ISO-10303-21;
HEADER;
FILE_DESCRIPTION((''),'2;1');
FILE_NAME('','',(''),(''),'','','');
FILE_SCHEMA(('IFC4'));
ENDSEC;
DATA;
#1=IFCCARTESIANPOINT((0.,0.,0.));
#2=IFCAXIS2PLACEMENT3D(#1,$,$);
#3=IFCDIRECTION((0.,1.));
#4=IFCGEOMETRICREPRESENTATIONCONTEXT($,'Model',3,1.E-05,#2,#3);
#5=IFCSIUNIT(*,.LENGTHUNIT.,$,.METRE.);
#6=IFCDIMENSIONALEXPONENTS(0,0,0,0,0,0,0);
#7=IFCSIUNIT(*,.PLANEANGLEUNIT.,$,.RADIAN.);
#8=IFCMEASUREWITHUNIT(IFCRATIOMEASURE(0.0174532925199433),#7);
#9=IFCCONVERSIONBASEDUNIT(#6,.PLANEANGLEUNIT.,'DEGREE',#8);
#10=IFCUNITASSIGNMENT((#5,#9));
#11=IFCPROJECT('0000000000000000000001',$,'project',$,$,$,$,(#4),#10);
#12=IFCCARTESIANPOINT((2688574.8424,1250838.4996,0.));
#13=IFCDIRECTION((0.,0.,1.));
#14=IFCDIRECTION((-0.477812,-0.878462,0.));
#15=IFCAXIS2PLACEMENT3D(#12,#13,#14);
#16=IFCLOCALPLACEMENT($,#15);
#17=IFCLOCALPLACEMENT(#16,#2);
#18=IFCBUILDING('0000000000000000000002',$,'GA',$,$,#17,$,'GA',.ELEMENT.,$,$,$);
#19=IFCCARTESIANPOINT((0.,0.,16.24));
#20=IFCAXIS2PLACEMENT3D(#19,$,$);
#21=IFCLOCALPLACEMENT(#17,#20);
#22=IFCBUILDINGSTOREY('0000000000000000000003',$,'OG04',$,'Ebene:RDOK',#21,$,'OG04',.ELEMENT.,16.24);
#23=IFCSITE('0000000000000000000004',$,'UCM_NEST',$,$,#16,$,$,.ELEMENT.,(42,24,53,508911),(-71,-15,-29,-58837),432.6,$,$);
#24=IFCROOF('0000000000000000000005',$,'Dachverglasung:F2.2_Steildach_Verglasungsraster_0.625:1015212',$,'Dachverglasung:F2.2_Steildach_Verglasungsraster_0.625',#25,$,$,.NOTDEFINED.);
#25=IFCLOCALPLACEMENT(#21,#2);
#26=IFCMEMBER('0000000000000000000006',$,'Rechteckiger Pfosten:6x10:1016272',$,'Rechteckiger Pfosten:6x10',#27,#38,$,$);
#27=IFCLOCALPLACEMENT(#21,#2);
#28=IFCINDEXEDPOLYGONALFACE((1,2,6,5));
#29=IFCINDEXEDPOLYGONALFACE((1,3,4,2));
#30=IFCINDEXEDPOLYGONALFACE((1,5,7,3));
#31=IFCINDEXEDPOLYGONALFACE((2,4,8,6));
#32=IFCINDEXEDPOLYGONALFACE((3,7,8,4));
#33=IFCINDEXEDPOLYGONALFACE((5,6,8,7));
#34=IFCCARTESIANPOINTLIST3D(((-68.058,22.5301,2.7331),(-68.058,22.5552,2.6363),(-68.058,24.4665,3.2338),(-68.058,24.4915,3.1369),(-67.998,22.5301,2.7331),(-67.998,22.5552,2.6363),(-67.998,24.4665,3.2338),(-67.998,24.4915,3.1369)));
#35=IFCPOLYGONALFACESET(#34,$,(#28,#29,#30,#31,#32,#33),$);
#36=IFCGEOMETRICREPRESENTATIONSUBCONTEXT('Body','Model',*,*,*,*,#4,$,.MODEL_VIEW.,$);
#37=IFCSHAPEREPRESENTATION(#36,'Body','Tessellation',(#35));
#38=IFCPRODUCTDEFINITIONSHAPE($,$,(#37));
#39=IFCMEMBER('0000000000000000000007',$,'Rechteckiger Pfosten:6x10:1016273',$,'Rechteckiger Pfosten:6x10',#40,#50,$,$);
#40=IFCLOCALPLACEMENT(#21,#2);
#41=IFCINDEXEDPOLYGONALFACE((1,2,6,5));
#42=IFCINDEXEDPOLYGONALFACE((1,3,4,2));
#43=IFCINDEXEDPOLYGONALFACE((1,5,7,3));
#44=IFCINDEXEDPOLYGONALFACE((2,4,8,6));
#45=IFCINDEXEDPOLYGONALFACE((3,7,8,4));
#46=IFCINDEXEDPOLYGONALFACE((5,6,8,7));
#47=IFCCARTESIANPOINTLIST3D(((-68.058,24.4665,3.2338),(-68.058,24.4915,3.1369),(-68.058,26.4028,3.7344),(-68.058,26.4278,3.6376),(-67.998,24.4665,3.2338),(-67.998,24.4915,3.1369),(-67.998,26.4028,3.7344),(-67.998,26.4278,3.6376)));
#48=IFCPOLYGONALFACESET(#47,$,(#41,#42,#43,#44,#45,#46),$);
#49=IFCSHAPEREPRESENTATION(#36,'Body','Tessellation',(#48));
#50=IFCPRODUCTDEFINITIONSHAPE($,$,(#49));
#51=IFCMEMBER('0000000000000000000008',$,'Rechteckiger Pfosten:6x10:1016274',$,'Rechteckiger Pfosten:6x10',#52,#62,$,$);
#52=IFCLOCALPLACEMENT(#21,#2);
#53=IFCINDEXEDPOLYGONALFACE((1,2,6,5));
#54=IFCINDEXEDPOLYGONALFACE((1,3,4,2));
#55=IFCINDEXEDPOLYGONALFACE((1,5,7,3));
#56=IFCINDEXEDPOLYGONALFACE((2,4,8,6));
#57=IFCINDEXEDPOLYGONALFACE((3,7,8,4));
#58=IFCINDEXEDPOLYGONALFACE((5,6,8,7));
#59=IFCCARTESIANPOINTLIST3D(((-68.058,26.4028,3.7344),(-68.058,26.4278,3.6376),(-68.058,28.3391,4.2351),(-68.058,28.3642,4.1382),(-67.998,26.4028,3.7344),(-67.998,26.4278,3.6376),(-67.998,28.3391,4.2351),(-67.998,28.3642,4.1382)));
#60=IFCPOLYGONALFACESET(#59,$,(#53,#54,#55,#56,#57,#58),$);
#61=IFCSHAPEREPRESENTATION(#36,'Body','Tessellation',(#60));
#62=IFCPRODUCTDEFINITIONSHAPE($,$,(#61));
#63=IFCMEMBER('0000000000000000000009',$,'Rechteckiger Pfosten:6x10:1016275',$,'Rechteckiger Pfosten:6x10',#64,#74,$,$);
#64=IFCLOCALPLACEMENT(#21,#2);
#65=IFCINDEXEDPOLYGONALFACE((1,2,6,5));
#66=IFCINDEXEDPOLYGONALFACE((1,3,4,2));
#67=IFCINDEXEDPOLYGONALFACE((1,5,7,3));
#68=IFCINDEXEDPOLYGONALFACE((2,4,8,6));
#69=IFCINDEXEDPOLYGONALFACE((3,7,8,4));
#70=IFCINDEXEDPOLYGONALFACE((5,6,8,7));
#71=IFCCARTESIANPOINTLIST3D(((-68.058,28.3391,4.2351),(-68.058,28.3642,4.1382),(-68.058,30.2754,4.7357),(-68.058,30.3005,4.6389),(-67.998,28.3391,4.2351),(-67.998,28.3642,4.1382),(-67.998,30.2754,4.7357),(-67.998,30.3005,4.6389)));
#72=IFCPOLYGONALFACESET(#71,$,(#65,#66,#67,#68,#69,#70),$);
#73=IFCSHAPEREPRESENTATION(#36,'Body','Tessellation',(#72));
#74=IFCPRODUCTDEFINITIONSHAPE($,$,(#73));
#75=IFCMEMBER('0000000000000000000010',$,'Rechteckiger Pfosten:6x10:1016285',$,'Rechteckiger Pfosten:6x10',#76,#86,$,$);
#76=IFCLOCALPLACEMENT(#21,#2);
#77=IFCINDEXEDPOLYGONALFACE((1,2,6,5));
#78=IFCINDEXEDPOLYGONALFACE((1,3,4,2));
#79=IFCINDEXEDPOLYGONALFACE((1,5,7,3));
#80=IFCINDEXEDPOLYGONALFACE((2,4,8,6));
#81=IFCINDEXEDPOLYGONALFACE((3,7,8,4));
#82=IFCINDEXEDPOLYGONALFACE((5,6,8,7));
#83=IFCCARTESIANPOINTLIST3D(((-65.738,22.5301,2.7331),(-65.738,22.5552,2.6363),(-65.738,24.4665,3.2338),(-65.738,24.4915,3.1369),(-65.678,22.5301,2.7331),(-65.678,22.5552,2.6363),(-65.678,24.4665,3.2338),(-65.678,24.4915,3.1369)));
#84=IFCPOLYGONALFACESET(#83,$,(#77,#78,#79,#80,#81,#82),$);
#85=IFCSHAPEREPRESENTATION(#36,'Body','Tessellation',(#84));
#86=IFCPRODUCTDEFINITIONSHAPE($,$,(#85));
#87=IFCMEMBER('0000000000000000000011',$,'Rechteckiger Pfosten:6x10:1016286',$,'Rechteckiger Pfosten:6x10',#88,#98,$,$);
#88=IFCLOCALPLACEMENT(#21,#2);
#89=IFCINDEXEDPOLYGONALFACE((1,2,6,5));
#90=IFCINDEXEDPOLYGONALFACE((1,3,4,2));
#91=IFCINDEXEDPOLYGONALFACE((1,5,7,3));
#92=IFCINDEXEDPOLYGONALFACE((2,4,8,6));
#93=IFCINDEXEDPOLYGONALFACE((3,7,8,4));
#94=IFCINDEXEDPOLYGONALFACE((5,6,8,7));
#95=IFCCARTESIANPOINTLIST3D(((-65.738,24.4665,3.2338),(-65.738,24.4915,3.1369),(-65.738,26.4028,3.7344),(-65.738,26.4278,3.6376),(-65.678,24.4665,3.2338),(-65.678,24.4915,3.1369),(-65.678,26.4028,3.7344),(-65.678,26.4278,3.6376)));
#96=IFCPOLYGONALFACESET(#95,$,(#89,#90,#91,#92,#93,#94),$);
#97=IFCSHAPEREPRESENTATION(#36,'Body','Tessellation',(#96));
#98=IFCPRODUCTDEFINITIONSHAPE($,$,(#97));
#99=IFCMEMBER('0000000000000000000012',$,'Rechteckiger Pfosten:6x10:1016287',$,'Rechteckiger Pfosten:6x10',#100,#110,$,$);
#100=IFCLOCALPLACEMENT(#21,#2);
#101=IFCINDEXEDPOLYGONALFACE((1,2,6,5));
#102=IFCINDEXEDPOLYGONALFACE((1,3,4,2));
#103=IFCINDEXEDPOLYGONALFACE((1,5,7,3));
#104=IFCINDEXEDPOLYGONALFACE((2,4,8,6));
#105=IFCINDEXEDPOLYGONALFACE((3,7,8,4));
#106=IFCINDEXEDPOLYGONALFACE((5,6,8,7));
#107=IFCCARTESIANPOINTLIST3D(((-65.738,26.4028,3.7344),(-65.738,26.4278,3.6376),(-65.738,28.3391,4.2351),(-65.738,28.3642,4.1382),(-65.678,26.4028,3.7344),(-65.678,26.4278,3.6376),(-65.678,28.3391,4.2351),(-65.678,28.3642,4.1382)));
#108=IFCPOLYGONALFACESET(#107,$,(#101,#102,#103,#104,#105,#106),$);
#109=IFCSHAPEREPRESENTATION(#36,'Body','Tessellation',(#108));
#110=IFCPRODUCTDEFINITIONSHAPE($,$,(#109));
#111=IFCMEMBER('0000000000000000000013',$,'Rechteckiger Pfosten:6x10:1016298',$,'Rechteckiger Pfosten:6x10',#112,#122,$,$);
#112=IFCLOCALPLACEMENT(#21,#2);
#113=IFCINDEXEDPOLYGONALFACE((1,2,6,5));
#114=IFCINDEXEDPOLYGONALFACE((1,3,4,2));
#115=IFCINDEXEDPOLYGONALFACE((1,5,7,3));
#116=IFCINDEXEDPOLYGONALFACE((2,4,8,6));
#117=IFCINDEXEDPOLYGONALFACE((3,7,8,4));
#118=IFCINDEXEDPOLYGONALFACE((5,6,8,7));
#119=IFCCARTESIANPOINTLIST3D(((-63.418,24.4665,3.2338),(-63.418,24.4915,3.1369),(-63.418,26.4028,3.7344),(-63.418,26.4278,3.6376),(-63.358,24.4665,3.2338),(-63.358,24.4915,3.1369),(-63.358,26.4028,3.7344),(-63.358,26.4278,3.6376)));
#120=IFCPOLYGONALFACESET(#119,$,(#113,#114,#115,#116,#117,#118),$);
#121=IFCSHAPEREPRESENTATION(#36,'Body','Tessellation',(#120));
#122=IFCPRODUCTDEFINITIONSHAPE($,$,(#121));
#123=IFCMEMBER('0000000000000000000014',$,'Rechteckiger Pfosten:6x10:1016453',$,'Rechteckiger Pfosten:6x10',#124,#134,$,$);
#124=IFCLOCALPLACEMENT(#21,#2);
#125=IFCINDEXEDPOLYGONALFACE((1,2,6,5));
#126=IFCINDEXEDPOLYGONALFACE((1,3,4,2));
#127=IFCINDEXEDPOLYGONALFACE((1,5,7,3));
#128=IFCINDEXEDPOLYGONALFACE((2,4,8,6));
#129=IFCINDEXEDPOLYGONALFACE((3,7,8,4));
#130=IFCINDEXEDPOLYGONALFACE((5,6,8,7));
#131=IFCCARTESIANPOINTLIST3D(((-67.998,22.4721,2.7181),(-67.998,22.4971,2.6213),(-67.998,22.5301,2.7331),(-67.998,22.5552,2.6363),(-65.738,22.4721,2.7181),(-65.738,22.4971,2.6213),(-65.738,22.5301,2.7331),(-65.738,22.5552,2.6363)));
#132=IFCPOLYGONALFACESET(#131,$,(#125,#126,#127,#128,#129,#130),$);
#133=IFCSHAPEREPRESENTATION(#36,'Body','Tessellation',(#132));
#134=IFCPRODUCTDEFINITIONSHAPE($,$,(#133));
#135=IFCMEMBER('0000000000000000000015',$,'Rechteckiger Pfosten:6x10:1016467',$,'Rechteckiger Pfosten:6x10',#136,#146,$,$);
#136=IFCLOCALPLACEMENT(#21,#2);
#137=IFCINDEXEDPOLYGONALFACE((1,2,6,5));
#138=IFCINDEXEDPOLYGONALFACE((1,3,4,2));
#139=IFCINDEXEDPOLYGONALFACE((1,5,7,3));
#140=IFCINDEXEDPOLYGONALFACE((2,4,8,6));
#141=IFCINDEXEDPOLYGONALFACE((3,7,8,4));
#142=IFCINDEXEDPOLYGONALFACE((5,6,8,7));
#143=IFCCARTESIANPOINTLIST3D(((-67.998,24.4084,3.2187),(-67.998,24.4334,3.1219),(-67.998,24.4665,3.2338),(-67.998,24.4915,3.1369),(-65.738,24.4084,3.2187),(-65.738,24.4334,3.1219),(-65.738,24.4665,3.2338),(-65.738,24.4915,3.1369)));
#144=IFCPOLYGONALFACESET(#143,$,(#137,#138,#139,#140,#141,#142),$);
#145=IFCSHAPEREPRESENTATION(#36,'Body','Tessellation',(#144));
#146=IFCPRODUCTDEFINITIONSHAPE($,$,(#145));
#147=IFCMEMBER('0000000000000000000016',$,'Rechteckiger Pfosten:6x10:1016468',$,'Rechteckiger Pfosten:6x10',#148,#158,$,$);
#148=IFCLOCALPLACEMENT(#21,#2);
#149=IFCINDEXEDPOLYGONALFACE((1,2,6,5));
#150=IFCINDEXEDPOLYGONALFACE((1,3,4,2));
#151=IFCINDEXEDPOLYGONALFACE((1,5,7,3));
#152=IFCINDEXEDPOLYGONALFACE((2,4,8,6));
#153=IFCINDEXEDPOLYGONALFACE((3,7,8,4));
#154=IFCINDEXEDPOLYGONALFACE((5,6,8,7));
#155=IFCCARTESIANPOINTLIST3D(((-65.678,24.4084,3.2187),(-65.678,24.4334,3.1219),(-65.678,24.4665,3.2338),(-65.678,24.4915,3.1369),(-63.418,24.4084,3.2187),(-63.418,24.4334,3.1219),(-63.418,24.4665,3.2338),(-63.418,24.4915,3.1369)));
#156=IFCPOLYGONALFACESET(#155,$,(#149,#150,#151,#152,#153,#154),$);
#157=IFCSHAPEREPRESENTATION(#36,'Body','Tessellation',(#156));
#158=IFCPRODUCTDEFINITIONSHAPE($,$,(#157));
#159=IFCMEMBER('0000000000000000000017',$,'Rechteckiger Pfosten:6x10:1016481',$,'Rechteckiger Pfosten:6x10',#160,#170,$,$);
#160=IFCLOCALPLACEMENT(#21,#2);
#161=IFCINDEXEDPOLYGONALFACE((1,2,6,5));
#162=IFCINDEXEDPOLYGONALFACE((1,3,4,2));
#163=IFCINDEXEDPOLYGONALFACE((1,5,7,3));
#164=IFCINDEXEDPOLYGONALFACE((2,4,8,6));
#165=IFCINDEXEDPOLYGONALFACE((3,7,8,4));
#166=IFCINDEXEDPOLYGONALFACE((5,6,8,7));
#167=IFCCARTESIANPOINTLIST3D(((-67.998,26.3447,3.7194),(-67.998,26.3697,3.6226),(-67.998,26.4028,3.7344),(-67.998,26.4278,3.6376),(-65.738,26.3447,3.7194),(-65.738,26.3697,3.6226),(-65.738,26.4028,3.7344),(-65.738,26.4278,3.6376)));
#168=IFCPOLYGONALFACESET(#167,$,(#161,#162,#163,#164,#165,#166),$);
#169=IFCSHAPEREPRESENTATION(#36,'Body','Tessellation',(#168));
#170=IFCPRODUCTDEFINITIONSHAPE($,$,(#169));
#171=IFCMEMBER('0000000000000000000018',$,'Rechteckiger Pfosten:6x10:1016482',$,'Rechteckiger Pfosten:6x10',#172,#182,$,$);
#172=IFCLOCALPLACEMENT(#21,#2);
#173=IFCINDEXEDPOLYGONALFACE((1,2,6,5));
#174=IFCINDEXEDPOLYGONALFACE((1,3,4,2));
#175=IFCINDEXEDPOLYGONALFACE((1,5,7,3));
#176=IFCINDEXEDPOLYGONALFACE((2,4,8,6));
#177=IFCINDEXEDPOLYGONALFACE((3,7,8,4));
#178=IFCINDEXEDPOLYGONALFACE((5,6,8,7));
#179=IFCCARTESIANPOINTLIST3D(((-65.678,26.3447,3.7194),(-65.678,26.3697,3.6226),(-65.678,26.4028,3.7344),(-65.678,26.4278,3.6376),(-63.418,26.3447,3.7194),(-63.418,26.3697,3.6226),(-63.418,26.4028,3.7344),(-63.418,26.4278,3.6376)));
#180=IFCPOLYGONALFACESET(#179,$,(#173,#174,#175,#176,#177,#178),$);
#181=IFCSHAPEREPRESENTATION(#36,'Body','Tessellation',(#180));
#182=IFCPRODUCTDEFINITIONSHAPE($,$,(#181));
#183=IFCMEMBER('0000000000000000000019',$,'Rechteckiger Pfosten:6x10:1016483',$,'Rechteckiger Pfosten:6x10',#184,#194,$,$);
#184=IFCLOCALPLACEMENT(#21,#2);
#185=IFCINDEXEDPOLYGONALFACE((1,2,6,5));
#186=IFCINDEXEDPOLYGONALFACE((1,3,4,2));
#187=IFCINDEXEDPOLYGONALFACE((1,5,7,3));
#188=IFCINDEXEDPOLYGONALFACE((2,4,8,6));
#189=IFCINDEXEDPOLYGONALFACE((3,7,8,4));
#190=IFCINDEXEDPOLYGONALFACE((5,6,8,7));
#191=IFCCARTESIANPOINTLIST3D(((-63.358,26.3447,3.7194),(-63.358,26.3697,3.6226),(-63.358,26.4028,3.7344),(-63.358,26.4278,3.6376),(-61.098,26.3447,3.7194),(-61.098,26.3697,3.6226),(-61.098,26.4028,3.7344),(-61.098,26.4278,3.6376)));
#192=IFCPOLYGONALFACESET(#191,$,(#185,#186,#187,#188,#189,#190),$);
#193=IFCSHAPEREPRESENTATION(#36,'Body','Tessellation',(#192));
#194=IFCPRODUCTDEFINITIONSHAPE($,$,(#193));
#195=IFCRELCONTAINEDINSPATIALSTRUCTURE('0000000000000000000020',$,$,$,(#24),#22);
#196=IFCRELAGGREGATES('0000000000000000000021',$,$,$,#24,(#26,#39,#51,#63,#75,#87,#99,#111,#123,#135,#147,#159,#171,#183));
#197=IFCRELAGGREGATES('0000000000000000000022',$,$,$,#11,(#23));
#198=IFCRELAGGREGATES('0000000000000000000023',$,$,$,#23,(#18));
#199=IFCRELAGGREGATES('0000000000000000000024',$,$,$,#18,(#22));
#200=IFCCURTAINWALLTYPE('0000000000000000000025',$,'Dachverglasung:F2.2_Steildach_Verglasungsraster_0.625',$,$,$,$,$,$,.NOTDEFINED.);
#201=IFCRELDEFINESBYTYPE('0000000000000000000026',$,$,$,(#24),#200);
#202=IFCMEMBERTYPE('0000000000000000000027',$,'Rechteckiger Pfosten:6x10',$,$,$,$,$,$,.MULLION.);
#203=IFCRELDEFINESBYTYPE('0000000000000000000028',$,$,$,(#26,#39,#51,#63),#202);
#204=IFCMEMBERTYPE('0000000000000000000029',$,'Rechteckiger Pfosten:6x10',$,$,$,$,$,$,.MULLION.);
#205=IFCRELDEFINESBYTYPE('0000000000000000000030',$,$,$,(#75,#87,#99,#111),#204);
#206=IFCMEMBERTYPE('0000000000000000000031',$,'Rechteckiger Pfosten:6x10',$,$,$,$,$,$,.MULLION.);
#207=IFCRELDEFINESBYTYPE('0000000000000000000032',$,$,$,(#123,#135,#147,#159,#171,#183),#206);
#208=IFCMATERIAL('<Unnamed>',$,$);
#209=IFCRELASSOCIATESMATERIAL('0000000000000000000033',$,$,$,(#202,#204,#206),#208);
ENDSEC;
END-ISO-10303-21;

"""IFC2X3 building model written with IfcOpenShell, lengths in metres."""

from ifc_helpers import new_model, entity, si_unit, converted_unit, direction, frame, origin, origin_2d_with_axis, place, context, subcontext, project, spatial, rectangle, extrude, source, transform, mapped, material, type_object, type_shapes, element, aggregate, save


model = new_model("IFC2X3")

# Units and contexts
model_context = context("Model", 3, precision=1e-05, world=origin(), true_north=direction((0.0, 1.0)))
body_context = subcontext(model_context, "Body", "Model", "MODEL_VIEW")
ifc_project = project(units=[si_unit("LENGTHUNIT", "METRE"), converted_unit("PLANEANGLEUNIT", "DEGREE", entity("IfcRatioMeasure", 0.0174532925199433), si_unit("PLANEANGLEUNIT", "RADIAN"), dimensions=[0, 0, 0, 0, 0, 0, 0])], contexts=[model_context])

# Site, building, storey
site_placement = place(None, frame((2688574.8424, 1250838.4996, 0.0), z_axis=(0.0, 0.0, 1.0), x_axis=(-0.477812, -0.878462, 0.0)))
site = spatial("IfcSite", under=ifc_project, at=site_placement, Name="UCM_NEST", CompositionType="ELEMENT", RefLatitude=(42, 24, 53, 508911), RefLongitude=(-71, -15, -29, -58837), RefElevation=432.6)
building_placement = place(site_placement, origin())
building = spatial("IfcBuilding", under=site, at=building_placement, Name="GA", LongName="GA", CompositionType="ELEMENT")
storey_placement = place(building_placement, frame((0.0, 0.0, 16.24)))
storey = spatial("IfcBuildingStorey", under=building, at=storey_placement, Name="OG04", ObjectType="Ebene:RDOK", LongName="OG04", CompositionType="ELEMENT", Elevation=16.24)

# Roof, members
curtain_wall_type = type_object("IfcCurtainWallType", Name="Dachverglasung:F2.2_Steildach_Verglasungsraster_0.625", PredefinedType="NOTDEFINED")
roof_placement = place(storey_placement, frame((0.0, 0.0, -16.24)))
roof = element("IfcRoof", 1, at=roof_placement, inside=storey, type_object=curtain_wall_type, Name="Dachverglasung:F2.2_Steildach_Verglasungsraster_0.625:1015212", ObjectType="Dachverglasung:F2.2_Steildach_Verglasungsraster_0.625", ShapeType="NOTDEFINED")
ifc_material_1 = material(Name="<Unnamed>")
member_type_1 = type_object("IfcMemberType", Name="Rechteckiger Pfosten:6x10", PredefinedType="MULLION", material=ifc_material_1)
shared_shape_1 = source(origin(), body_context, "Body", "SweptSolid", [
    extrude(rectangle(XDim=0.1, YDim=0.06, at=origin_2d_with_axis()), frame((-0.03, -0.05, -2.0), z_axis=(0.0, 0.0, 1.0), x_axis=(0.0, -1.0, 0.0)), (0.0, 0.0, 1.0), 2.0),
])
type_shapes(member_type_1, [shared_shape_1])
member_1_placement = place(roof_placement, frame((-68.058, 22.5552, 18.8763), z_axis=(0.0, -0.968163, -0.250322), x_axis=(-1.0, 0.0, 0.0)))
member_1 = element("IfcMember", 2, at=member_1_placement, type_object=member_type_1, Name="Rechteckiger Pfosten:6x10:1016272", ObjectType="Rechteckiger Pfosten:6x10", context=body_context, shape_type="MappedRepresentation", body=[
    mapped(shared_shape_1, transform((0.0, 0.0, 0.0), scale=1.0)),
])
member_2_placement = place(roof_placement, frame((-68.058, 24.4915, 19.3769), z_axis=(0.0, -0.968163, -0.250322), x_axis=(-1.0, 0.0, 0.0)))
member_2 = element("IfcMember", 3, at=member_2_placement, type_object=member_type_1, Name="Rechteckiger Pfosten:6x10:1016273", ObjectType="Rechteckiger Pfosten:6x10", context=body_context, shape_type="MappedRepresentation", body=[
    mapped(shared_shape_1, transform((0.0, 0.0, 0.0), scale=1.0)),
])
member_3_placement = place(roof_placement, frame((-68.058, 26.4278, 19.8776), z_axis=(0.0, -0.968163, -0.250322), x_axis=(-1.0, 0.0, 0.0)))
member_3 = element("IfcMember", 4, at=member_3_placement, type_object=member_type_1, Name="Rechteckiger Pfosten:6x10:1016274", ObjectType="Rechteckiger Pfosten:6x10", context=body_context, shape_type="MappedRepresentation", body=[
    mapped(shared_shape_1, transform((0.0, 0.0, 0.0), scale=1.0)),
])
member_4_placement = place(roof_placement, frame((-68.058, 28.3642, 20.3782), z_axis=(0.0, -0.968163, -0.250322), x_axis=(-1.0, 0.0, 0.0)))
member_4 = element("IfcMember", 5, at=member_4_placement, type_object=member_type_1, Name="Rechteckiger Pfosten:6x10:1016275", ObjectType="Rechteckiger Pfosten:6x10", context=body_context, shape_type="MappedRepresentation", body=[
    mapped(shared_shape_1, transform((0.0, 0.0, 0.0), scale=1.0)),
])
member_type_2 = type_object("IfcMemberType", Name="Rechteckiger Pfosten:6x10", PredefinedType="MULLION", material=ifc_material_1)
shared_shape_2 = source(origin(), body_context, "Body", "SweptSolid", [
    extrude(rectangle(XDim=0.1, YDim=0.06, at=origin_2d_with_axis()), frame((-0.03, -0.05, -2.0), z_axis=(0.0, 0.0, 1.0), x_axis=(0.0, -1.0, 0.0)), (0.0, 0.0, 1.0), 2.0),
])
type_shapes(member_type_2, [shared_shape_2])
member_5_placement = place(roof_placement, frame((-65.678, 24.4915, 19.3769), z_axis=(0.0, 0.968163, 0.250322), x_axis=(1.0, 0.0, 0.0)))
member_5 = element("IfcMember", 6, at=member_5_placement, type_object=member_type_2, Name="Rechteckiger Pfosten:6x10:1016285", ObjectType="Rechteckiger Pfosten:6x10", context=body_context, shape_type="MappedRepresentation", body=[
    mapped(shared_shape_2, transform((0.0, 0.0, 0.0), scale=1.0)),
])
member_6_placement = place(roof_placement, frame((-65.678, 26.4278, 19.8776), z_axis=(0.0, 0.968163, 0.250322), x_axis=(1.0, 0.0, 0.0)))
member_6 = element("IfcMember", 7, at=member_6_placement, type_object=member_type_2, Name="Rechteckiger Pfosten:6x10:1016286", ObjectType="Rechteckiger Pfosten:6x10", context=body_context, shape_type="MappedRepresentation", body=[
    mapped(shared_shape_2, transform((0.0, 0.0, 0.0), scale=1.0)),
])
member_7_placement = place(roof_placement, frame((-65.678, 28.3642, 20.3782), z_axis=(0.0, 0.968163, 0.250322), x_axis=(1.0, 0.0, 0.0)))
member_7 = element("IfcMember", 8, at=member_7_placement, type_object=member_type_2, Name="Rechteckiger Pfosten:6x10:1016287", ObjectType="Rechteckiger Pfosten:6x10", context=body_context, shape_type="MappedRepresentation", body=[
    mapped(shared_shape_2, transform((0.0, 0.0, 0.0), scale=1.0)),
])
member_8_placement = place(roof_placement, frame((-63.358, 26.4278, 19.8776), z_axis=(0.0, 0.968163, 0.250322), x_axis=(1.0, 0.0, 0.0)))
member_8 = element("IfcMember", 9, at=member_8_placement, type_object=member_type_2, Name="Rechteckiger Pfosten:6x10:1016298", ObjectType="Rechteckiger Pfosten:6x10", context=body_context, shape_type="MappedRepresentation", body=[
    mapped(shared_shape_2, transform((0.0, 0.0, 0.0), scale=1.0)),
])
member_type_3 = type_object("IfcMemberType", Name="Rechteckiger Pfosten:6x10", PredefinedType="MULLION", material=ifc_material_1)
shared_shape_3 = source(origin(), body_context, "Body", "SweptSolid", [
    extrude(rectangle(XDim=0.1, YDim=0.06, at=origin_2d_with_axis()), frame((-0.03, -0.05, -2.26), z_axis=(0.0, 0.0, 1.0), x_axis=(0.0, -1.0, 0.0)), (0.0, 0.0, 1.0), 2.26),
])
type_shapes(member_type_3, [shared_shape_3])
member_9_placement = place(roof_placement, frame((-67.998, 22.5552, 18.8763), z_axis=(-1.0, 0.0, 0.0), x_axis=(0.0, 0.968163, 0.250322)))
member_9 = element("IfcMember", 10, at=member_9_placement, type_object=member_type_3, Name="Rechteckiger Pfosten:6x10:1016453", ObjectType="Rechteckiger Pfosten:6x10", context=body_context, shape_type="MappedRepresentation", body=[
    mapped(shared_shape_3, transform((0.0, 0.0, 0.0), scale=1.0)),
])
member_10_placement = place(roof_placement, frame((-67.998, 24.4915, 19.3769), z_axis=(-1.0, 0.0, 0.0), x_axis=(0.0, 0.968163, 0.250322)))
member_10 = element("IfcMember", 11, at=member_10_placement, type_object=member_type_3, Name="Rechteckiger Pfosten:6x10:1016467", ObjectType="Rechteckiger Pfosten:6x10", context=body_context, shape_type="MappedRepresentation", body=[
    mapped(shared_shape_3, transform((0.0, 0.0, 0.0), scale=1.0)),
])
member_11_placement = place(roof_placement, frame((-65.678, 24.4915, 19.3769), z_axis=(-1.0, 0.0, 0.0), x_axis=(0.0, 0.968163, 0.250322)))
member_11 = element("IfcMember", 12, at=member_11_placement, type_object=member_type_3, Name="Rechteckiger Pfosten:6x10:1016468", ObjectType="Rechteckiger Pfosten:6x10", context=body_context, shape_type="MappedRepresentation", body=[
    mapped(shared_shape_3, transform((0.0, 0.0, 0.0), scale=1.0)),
])
member_12_placement = place(roof_placement, frame((-67.998, 26.4278, 19.8776), z_axis=(-1.0, 0.0, 0.0), x_axis=(0.0, 0.968163, 0.250322)))
member_12 = element("IfcMember", 13, at=member_12_placement, type_object=member_type_3, Name="Rechteckiger Pfosten:6x10:1016481", ObjectType="Rechteckiger Pfosten:6x10", context=body_context, shape_type="MappedRepresentation", body=[
    mapped(shared_shape_3, transform((0.0, 0.0, 0.0), scale=1.0)),
])
member_13_placement = place(roof_placement, frame((-65.678, 26.4278, 19.8776), z_axis=(-1.0, 0.0, 0.0), x_axis=(0.0, 0.968163, 0.250322)))
member_13 = element("IfcMember", 14, at=member_13_placement, type_object=member_type_3, Name="Rechteckiger Pfosten:6x10:1016482", ObjectType="Rechteckiger Pfosten:6x10", context=body_context, shape_type="MappedRepresentation", body=[
    mapped(shared_shape_3, transform((0.0, 0.0, 0.0), scale=1.0)),
])
member_14_placement = place(roof_placement, frame((-63.358, 26.4278, 19.8776), z_axis=(-1.0, 0.0, 0.0), x_axis=(0.0, 0.968163, 0.250322)))
member_14 = element("IfcMember", 15, at=member_14_placement, type_object=member_type_3, Name="Rechteckiger Pfosten:6x10:1016483", ObjectType="Rechteckiger Pfosten:6x10", context=body_context, shape_type="MappedRepresentation", body=[
    mapped(shared_shape_3, transform((0.0, 0.0, 0.0), scale=1.0)),
])
aggregate(roof, [member_1, member_2, member_3, member_4, member_5, member_6, member_7, member_8, member_9, member_10, member_11, member_12, member_13, member_14])

save(model, "model.ifc")
